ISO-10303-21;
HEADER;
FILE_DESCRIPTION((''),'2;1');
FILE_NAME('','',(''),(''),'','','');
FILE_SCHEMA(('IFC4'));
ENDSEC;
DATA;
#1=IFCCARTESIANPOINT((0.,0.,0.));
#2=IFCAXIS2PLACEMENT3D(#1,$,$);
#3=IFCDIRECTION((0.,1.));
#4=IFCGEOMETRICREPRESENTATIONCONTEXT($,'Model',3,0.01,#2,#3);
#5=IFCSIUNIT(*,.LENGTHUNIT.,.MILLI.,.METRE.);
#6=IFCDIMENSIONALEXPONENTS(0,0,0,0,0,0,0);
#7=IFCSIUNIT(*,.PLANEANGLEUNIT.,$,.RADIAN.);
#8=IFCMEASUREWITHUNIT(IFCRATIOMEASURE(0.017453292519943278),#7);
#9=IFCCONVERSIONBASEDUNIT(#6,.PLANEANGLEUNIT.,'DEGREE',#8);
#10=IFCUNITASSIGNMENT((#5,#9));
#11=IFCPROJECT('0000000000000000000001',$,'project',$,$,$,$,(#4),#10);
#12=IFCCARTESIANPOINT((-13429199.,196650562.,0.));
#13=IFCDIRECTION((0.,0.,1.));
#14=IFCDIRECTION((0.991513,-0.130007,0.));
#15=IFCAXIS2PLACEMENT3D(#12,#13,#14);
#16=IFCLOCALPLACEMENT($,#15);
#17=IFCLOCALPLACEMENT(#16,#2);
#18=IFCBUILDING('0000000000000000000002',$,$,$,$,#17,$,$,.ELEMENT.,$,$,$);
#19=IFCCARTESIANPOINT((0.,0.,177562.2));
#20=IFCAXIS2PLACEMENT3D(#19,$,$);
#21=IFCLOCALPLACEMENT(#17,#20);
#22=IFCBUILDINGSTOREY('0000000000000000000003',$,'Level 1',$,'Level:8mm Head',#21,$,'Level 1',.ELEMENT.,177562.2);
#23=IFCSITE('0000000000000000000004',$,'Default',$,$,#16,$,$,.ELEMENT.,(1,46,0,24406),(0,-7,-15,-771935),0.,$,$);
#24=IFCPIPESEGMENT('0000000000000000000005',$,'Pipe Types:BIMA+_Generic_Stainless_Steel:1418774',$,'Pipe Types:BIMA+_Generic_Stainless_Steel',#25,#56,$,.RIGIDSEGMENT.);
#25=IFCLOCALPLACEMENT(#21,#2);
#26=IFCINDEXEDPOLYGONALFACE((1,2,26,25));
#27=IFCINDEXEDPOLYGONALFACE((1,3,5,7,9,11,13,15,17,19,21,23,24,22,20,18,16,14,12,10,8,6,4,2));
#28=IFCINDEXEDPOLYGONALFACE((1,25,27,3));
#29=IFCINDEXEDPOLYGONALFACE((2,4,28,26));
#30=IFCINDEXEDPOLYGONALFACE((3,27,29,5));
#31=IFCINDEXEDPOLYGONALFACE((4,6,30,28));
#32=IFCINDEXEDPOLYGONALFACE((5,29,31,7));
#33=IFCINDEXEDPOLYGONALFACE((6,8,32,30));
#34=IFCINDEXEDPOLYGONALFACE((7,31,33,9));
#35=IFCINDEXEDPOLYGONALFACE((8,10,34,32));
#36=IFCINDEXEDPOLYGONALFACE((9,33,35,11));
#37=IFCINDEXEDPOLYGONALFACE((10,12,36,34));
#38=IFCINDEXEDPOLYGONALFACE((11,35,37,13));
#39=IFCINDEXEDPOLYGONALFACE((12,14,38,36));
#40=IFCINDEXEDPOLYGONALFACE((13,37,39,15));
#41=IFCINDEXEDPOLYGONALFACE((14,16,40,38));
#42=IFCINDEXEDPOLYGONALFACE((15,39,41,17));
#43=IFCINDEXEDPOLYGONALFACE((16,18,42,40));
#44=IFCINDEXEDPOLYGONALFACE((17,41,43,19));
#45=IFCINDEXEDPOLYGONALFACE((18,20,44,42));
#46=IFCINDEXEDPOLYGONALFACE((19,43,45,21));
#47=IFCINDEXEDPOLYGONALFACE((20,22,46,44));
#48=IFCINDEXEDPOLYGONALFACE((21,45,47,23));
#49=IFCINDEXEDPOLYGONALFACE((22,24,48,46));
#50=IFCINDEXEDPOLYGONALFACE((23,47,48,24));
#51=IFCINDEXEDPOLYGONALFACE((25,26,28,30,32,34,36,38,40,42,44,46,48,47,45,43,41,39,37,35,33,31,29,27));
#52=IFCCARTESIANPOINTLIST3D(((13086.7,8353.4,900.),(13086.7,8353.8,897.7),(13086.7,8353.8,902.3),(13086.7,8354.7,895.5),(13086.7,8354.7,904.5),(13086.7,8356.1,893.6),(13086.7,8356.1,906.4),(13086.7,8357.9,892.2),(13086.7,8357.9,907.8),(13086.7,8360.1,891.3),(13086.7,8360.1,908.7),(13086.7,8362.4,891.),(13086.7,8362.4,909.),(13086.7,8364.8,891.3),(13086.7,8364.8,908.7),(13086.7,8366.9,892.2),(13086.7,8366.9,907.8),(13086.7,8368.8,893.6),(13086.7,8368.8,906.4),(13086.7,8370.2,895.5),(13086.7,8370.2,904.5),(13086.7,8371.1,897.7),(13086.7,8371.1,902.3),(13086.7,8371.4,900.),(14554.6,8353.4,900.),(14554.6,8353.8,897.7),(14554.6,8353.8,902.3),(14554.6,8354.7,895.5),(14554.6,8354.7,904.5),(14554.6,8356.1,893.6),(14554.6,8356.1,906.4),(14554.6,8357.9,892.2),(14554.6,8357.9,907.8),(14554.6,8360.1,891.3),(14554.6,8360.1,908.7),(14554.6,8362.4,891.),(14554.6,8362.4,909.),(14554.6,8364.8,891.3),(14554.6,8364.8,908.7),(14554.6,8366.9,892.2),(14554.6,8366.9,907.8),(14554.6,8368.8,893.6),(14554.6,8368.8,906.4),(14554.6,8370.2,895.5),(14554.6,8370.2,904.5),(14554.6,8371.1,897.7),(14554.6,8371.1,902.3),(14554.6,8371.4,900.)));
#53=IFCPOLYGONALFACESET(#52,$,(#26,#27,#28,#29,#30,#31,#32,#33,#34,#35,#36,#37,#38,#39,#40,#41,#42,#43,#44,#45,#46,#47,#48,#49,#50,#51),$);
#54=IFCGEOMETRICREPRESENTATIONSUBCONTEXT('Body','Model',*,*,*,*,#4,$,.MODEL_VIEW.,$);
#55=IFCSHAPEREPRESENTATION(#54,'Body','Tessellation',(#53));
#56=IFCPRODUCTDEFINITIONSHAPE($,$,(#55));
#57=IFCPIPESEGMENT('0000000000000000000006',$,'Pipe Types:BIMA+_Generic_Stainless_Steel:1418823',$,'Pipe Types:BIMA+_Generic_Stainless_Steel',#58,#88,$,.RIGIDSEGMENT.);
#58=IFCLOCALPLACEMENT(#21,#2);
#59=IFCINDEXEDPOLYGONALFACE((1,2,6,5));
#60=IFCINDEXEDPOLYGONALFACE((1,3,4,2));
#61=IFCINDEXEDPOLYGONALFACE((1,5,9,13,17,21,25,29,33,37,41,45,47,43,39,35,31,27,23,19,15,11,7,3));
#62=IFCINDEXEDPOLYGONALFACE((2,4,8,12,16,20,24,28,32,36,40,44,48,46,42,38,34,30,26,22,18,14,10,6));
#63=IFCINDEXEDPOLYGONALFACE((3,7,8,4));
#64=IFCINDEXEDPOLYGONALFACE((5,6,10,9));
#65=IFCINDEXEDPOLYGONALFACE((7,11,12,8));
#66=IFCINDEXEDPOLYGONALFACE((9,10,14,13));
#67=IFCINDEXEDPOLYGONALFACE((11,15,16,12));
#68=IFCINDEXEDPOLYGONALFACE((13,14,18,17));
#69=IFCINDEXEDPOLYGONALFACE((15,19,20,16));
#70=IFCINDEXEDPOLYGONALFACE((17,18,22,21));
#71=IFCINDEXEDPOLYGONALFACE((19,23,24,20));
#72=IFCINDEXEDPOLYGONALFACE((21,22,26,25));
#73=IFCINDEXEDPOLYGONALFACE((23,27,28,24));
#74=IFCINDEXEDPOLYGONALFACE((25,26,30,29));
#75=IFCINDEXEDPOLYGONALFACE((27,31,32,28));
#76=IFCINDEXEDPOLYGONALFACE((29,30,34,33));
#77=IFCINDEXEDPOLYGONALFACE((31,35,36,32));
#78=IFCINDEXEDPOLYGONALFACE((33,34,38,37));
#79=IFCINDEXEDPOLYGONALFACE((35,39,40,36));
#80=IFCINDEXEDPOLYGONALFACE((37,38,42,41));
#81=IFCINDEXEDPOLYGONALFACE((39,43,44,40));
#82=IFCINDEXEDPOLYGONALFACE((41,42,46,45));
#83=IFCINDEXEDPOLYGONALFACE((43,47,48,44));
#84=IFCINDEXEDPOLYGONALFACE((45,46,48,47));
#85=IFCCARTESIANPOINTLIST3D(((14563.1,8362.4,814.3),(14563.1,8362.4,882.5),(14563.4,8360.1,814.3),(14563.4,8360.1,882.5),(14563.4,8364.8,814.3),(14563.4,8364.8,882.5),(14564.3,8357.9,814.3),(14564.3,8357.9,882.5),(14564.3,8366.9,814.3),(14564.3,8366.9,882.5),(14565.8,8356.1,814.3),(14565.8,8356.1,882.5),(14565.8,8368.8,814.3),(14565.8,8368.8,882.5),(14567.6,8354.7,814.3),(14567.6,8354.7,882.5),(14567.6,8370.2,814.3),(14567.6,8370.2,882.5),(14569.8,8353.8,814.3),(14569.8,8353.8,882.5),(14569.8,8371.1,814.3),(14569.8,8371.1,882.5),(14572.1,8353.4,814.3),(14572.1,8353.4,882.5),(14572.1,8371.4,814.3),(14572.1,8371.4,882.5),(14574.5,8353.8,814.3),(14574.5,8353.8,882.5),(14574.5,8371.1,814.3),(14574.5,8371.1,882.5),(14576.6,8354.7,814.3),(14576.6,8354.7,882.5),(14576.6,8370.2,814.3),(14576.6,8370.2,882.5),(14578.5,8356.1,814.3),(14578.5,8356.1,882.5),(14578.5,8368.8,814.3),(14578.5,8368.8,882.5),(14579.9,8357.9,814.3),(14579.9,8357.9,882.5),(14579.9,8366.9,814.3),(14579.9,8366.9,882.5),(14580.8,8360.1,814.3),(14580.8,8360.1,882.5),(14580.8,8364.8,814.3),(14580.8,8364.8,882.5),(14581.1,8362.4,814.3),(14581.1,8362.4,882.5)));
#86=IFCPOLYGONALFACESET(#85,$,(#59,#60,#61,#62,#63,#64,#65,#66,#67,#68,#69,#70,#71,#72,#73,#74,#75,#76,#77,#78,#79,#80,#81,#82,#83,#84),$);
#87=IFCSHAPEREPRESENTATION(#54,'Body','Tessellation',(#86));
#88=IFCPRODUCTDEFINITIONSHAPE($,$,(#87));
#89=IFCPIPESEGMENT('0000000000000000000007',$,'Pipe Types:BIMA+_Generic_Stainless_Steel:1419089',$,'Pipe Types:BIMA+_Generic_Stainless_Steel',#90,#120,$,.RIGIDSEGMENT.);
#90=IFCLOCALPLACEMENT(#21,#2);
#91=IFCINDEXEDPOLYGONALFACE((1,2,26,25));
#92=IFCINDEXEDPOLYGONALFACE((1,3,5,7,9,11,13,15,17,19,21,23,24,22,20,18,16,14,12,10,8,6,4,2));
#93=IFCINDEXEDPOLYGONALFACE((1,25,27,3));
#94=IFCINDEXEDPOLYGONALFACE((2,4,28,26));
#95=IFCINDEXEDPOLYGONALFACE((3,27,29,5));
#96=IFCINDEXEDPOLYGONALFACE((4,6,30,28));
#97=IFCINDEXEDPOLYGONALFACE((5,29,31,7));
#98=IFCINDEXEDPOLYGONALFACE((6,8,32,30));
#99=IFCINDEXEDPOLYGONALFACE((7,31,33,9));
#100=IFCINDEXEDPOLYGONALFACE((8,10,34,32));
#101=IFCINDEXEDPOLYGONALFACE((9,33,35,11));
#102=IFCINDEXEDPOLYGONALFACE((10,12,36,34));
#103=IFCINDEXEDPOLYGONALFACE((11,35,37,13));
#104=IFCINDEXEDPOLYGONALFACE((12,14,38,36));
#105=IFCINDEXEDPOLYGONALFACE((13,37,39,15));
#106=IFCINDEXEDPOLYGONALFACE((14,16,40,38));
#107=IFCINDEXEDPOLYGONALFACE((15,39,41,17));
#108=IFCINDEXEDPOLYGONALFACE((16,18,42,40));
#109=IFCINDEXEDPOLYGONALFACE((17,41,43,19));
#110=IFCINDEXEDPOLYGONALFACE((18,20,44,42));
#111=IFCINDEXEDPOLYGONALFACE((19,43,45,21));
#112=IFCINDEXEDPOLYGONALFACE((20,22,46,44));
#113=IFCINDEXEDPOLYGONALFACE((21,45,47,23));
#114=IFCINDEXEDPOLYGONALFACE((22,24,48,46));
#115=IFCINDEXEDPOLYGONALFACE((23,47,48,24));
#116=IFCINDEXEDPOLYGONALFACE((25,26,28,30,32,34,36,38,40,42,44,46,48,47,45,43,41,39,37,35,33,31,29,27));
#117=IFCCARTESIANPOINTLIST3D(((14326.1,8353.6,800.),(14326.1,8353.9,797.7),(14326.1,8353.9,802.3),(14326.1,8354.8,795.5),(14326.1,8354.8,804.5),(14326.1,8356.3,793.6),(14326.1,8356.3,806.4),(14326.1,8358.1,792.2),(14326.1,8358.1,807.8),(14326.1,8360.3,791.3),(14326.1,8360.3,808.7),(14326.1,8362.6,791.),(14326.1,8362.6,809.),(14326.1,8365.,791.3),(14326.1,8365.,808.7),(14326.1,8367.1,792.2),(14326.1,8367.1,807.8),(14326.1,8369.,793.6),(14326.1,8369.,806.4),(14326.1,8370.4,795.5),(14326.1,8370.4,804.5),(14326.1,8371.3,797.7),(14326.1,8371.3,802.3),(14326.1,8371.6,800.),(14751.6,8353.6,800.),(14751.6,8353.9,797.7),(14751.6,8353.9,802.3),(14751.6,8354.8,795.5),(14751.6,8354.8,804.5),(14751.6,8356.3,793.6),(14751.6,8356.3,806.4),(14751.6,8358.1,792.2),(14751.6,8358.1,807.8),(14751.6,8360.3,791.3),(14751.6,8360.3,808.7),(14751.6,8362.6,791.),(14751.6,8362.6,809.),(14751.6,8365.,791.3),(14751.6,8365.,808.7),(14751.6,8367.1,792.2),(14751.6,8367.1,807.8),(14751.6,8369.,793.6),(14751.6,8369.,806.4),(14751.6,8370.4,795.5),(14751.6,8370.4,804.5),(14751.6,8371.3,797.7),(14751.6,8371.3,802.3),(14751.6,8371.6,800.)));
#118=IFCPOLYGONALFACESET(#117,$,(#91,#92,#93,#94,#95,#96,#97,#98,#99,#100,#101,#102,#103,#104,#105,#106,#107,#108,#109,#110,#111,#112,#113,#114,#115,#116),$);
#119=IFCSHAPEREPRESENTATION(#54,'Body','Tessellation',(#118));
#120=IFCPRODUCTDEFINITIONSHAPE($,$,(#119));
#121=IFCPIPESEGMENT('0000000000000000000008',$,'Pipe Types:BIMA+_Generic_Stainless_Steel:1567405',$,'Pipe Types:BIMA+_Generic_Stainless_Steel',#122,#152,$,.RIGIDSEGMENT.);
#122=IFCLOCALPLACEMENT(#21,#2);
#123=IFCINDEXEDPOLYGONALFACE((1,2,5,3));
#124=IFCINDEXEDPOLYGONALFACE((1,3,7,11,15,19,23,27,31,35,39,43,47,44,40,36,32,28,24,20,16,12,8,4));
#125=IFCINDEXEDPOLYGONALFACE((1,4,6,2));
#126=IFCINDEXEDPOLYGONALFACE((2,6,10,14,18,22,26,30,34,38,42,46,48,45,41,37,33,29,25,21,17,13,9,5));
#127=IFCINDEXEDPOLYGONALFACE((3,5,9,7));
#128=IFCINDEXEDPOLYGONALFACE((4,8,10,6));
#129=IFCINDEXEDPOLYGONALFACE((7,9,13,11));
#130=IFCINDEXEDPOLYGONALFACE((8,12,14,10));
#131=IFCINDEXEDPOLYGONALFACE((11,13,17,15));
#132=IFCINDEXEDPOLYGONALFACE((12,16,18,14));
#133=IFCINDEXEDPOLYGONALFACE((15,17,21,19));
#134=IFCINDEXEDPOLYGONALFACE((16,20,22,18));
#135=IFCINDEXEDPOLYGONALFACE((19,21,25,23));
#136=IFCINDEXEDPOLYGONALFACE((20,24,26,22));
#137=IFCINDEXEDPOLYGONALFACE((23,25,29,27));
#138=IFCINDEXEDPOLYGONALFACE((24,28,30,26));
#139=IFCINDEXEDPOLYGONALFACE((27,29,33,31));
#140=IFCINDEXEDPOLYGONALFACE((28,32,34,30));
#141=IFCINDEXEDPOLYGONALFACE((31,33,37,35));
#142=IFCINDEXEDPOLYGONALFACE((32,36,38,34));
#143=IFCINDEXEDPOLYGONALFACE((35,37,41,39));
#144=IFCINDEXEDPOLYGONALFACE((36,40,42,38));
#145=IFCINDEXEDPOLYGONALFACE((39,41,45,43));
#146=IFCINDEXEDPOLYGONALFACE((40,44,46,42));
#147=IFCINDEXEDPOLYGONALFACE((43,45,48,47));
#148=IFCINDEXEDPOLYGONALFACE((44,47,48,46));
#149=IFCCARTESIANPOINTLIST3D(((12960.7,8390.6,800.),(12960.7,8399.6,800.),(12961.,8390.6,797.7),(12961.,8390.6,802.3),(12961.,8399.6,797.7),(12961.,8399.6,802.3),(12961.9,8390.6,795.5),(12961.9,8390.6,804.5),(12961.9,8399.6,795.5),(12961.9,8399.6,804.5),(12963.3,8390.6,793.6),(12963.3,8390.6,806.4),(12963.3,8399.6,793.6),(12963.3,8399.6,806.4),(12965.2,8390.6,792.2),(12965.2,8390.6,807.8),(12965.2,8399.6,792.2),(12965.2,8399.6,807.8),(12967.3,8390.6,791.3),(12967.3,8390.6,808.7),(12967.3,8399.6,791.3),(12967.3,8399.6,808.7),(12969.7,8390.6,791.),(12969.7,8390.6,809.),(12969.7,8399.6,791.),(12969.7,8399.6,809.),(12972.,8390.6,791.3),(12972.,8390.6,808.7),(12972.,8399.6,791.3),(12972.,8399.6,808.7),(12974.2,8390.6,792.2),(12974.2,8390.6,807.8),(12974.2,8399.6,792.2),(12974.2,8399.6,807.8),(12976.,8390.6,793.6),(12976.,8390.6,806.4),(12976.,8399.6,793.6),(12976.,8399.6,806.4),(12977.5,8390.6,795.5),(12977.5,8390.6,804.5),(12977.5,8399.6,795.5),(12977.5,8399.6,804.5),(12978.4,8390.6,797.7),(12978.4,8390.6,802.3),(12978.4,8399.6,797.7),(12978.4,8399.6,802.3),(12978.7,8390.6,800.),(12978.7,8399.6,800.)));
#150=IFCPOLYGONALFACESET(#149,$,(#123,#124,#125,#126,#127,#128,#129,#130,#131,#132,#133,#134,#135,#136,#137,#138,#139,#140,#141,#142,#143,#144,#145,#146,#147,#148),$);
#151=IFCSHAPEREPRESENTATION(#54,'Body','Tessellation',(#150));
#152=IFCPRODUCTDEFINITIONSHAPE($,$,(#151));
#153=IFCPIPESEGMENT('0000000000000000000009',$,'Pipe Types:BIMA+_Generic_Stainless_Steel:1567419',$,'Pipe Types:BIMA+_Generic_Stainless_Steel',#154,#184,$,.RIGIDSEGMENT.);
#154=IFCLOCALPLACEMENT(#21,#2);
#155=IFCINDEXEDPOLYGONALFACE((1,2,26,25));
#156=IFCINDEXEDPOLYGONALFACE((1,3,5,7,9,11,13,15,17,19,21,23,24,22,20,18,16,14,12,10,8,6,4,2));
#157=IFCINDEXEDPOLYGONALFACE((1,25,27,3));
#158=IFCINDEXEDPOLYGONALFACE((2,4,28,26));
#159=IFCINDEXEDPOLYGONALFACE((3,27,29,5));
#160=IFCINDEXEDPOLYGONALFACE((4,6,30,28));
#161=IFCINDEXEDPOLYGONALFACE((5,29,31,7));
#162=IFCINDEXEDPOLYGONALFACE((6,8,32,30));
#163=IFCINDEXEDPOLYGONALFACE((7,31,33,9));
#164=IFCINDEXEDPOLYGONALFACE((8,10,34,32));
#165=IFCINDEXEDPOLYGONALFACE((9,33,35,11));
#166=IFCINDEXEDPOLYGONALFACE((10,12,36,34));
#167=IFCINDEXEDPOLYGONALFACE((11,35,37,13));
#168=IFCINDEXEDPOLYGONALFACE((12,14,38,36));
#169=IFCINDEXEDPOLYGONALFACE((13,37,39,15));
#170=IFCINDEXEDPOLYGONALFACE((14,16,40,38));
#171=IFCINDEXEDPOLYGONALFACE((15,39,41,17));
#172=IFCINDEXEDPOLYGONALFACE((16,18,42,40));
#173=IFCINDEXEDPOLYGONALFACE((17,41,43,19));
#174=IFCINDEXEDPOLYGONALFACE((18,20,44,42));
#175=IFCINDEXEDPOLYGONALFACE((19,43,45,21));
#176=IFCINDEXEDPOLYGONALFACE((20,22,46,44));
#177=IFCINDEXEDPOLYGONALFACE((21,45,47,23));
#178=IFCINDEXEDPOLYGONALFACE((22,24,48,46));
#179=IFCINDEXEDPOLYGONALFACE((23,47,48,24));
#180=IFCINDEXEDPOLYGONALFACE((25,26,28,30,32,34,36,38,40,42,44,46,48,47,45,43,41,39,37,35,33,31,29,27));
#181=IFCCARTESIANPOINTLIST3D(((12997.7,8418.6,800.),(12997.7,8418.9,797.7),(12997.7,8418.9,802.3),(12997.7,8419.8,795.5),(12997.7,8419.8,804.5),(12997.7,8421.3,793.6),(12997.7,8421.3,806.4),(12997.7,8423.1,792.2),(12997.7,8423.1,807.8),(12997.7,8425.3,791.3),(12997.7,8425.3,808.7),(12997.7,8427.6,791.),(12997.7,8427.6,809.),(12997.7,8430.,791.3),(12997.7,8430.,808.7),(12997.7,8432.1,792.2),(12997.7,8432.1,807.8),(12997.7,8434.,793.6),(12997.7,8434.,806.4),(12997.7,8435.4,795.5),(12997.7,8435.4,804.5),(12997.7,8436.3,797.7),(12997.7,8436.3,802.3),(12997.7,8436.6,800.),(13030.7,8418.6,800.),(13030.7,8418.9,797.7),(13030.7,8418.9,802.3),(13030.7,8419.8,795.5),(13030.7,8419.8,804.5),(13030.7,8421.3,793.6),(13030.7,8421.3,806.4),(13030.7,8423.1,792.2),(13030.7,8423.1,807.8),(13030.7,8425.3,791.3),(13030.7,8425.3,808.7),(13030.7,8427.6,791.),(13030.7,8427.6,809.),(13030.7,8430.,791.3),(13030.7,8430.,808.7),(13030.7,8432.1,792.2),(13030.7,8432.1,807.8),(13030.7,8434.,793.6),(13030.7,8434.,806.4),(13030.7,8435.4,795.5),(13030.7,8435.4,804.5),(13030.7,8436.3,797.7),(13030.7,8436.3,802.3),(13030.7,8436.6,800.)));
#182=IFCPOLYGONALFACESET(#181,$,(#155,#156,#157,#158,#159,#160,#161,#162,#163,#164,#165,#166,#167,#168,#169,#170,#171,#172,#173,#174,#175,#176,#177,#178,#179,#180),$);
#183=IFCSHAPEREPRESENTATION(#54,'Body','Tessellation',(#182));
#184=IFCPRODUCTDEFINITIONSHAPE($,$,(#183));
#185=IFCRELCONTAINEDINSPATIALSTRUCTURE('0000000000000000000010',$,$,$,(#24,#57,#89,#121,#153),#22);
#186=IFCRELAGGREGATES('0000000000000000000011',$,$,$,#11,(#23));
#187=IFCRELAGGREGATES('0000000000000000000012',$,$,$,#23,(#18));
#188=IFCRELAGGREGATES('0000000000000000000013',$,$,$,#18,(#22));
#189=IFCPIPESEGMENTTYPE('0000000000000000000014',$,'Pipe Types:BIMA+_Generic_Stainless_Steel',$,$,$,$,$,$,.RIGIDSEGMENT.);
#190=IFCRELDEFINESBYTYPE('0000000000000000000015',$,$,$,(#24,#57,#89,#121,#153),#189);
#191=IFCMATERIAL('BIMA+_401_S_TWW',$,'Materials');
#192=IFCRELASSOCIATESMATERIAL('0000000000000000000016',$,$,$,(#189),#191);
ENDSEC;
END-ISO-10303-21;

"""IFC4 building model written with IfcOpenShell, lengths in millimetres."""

from ifc_helpers import new_model, entity, si_unit, converted_unit, direction, frame, origin, place, context, subcontext, project, spatial, arc, indexed_curve, outline, extrude, material, type_object, element, save


model = new_model("IFC4")

# Units and contexts
model_context = context("Model", 3, precision=0.01, world=origin(), true_north=direction((0.0, 1.0)))
body_context = subcontext(model_context, "Body", "Model", "MODEL_VIEW")
ifc_project = project(units=[si_unit("LENGTHUNIT", "METRE", prefix="MILLI"), converted_unit("PLANEANGLEUNIT", "DEGREE", entity("IfcRatioMeasure", 0.017453292519943278), si_unit("PLANEANGLEUNIT", "RADIAN"), dimensions=[0, 0, 0, 0, 0, 0, 0])], contexts=[model_context])

# Site, building, storey
site_placement = place(None, frame((-13429199.0, 196650562.0, 0.0), z_axis=(0.0, 0.0, 1.0), x_axis=(0.991513, -0.130007, 0.0)))
site = spatial("IfcSite", under=ifc_project, at=site_placement, Name="Default", CompositionType="ELEMENT", RefLatitude=(1, 46, 0, 24406), RefLongitude=(0, -7, -15, -771935), RefElevation=0.0)
building_placement = place(site_placement, origin())
building = spatial("IfcBuilding", under=site, at=building_placement, CompositionType="ELEMENT")
storey_placement = place(building_placement, frame((0.0, 0.0, 177562.2)))
storey = spatial("IfcBuildingStorey", under=building, at=storey_placement, Name="Level 1", ObjectType="Level:8mm Head", LongName="Level 1", CompositionType="ELEMENT", Elevation=177562.2)

# Pipe segments
ifc_material_1 = material(Name="BIMA+_401_S_TWW", Category="Materials")
pipe_segment_type_1 = type_object("IfcPipeSegmentType", Name="Pipe Types:BIMA+_Generic_Stainless_Steel", PredefinedType="RIGIDSEGMENT", material=ifc_material_1)
pipe_segment_1_placement = place(storey_placement, frame((13086.7, 8351.9, 889.4)))
element("IfcPipeSegment", 1, at=pipe_segment_1_placement, inside=storey, type_object=pipe_segment_type_1, Name="Pipe Types:BIMA+_Generic_Stainless_Steel:1418774", ObjectType="Pipe Types:BIMA+_Generic_Stainless_Steel", PredefinedType="RIGIDSEGMENT", context=body_context, shape_type="SweptSolid", body=[
    extrude(outline(indexed_curve([(9.0, 0.0), (6.4, 6.4), (0.0, 9.0), (-6.4, 6.4), (-9.0, 0.0), (-6.4, -6.4), (0.0, -9.0), (6.4, -6.4)], segments=[arc(1, 2, 3), arc(3, 4, 5), arc(5, 6, 7), arc(7, 8, 1)], self_intersect=False)), frame((0.0, 10.6, 10.6), z_axis=(1.0, 0.0, 0.0), x_axis=(0.0, -1.0, 0.0)), (0.0, 0.0, 1.0), 1468.0),
])
pipe_segment_2_placement = place(storey_placement, frame((14561.5, 8351.9, 814.3)))
element("IfcPipeSegment", 2, at=pipe_segment_2_placement, inside=storey, type_object=pipe_segment_type_1, Name="Pipe Types:BIMA+_Generic_Stainless_Steel:1418823", ObjectType="Pipe Types:BIMA+_Generic_Stainless_Steel", PredefinedType="RIGIDSEGMENT", context=body_context, shape_type="SweptSolid", body=[
    extrude(outline(indexed_curve([(9.0, 0.0), (6.4, 6.4), (0.0, 9.0), (-6.4, 6.4), (-9.0, 0.0), (-6.4, -6.4), (0.0, -9.0), (6.4, -6.4)], segments=[arc(1, 2, 3), arc(3, 4, 5), arc(5, 6, 7), arc(7, 8, 1)], self_intersect=False)), frame((10.6, 10.6, 0.0)), (0.0, 0.0, 1.0), 68.2),
])
pipe_segment_3_placement = place(storey_placement, frame((14326.1, 8352.0, 789.4)))
element("IfcPipeSegment", 3, at=pipe_segment_3_placement, inside=storey, type_object=pipe_segment_type_1, Name="Pipe Types:BIMA+_Generic_Stainless_Steel:1419089", ObjectType="Pipe Types:BIMA+_Generic_Stainless_Steel", PredefinedType="RIGIDSEGMENT", context=body_context, shape_type="SweptSolid", body=[
    extrude(outline(indexed_curve([(9.0, 0.0), (6.4, 6.4), (0.0, 9.0), (-6.4, 6.4), (-9.0, 0.0), (-6.4, -6.4), (0.0, -9.0), (6.4, -6.4)], segments=[arc(1, 2, 3), arc(3, 4, 5), arc(5, 6, 7), arc(7, 8, 1)], self_intersect=False)), frame((0.0, 10.6, 10.6), z_axis=(1.0, 0.0, 0.0), x_axis=(0.0, -1.0, 0.0)), (0.0, 0.0, 1.0), 425.5),
])
pipe_segment_4_placement = place(storey_placement, frame((12959.1, 8390.6, 789.4)))
element("IfcPipeSegment", 4, at=pipe_segment_4_placement, inside=storey, type_object=pipe_segment_type_1, Name="Pipe Types:BIMA+_Generic_Stainless_Steel:1567405", ObjectType="Pipe Types:BIMA+_Generic_Stainless_Steel", PredefinedType="RIGIDSEGMENT", context=body_context, shape_type="SweptSolid", body=[
    extrude(outline(indexed_curve([(9.0, 0.0), (6.4, 6.4), (0.0, 9.0), (-6.4, 6.4), (-9.0, 0.0), (-6.4, -6.4), (0.0, -9.0), (6.4, -6.4)], segments=[arc(1, 2, 3), arc(3, 4, 5), arc(5, 6, 7), arc(7, 8, 1)], self_intersect=False)), frame((10.6, 0.0, 10.6), z_axis=(0.0, 1.0, 0.0), x_axis=(1.0, 0.0, 0.0)), (0.0, 0.0, 1.0), 9.0),
])
pipe_segment_5_placement = place(storey_placement, frame((12997.7, 8417.0, 789.4)))
element("IfcPipeSegment", 5, at=pipe_segment_5_placement, inside=storey, type_object=pipe_segment_type_1, Name="Pipe Types:BIMA+_Generic_Stainless_Steel:1567419", ObjectType="Pipe Types:BIMA+_Generic_Stainless_Steel", PredefinedType="RIGIDSEGMENT", context=body_context, shape_type="SweptSolid", body=[
    extrude(outline(indexed_curve([(9.0, 0.0), (6.4, 6.4), (0.0, 9.0), (-6.4, 6.4), (-9.0, 0.0), (-6.4, -6.4), (0.0, -9.0), (6.4, -6.4)], segments=[arc(1, 2, 3), arc(3, 4, 5), arc(5, 6, 7), arc(7, 8, 1)], self_intersect=False)), frame((0.0, 10.6, 10.6), z_axis=(1.0, 0.0, 0.0), x_axis=(0.0, -1.0, 0.0)), (0.0, 0.0, 1.0), 33.0),
])

save(model, "model.ifc")
